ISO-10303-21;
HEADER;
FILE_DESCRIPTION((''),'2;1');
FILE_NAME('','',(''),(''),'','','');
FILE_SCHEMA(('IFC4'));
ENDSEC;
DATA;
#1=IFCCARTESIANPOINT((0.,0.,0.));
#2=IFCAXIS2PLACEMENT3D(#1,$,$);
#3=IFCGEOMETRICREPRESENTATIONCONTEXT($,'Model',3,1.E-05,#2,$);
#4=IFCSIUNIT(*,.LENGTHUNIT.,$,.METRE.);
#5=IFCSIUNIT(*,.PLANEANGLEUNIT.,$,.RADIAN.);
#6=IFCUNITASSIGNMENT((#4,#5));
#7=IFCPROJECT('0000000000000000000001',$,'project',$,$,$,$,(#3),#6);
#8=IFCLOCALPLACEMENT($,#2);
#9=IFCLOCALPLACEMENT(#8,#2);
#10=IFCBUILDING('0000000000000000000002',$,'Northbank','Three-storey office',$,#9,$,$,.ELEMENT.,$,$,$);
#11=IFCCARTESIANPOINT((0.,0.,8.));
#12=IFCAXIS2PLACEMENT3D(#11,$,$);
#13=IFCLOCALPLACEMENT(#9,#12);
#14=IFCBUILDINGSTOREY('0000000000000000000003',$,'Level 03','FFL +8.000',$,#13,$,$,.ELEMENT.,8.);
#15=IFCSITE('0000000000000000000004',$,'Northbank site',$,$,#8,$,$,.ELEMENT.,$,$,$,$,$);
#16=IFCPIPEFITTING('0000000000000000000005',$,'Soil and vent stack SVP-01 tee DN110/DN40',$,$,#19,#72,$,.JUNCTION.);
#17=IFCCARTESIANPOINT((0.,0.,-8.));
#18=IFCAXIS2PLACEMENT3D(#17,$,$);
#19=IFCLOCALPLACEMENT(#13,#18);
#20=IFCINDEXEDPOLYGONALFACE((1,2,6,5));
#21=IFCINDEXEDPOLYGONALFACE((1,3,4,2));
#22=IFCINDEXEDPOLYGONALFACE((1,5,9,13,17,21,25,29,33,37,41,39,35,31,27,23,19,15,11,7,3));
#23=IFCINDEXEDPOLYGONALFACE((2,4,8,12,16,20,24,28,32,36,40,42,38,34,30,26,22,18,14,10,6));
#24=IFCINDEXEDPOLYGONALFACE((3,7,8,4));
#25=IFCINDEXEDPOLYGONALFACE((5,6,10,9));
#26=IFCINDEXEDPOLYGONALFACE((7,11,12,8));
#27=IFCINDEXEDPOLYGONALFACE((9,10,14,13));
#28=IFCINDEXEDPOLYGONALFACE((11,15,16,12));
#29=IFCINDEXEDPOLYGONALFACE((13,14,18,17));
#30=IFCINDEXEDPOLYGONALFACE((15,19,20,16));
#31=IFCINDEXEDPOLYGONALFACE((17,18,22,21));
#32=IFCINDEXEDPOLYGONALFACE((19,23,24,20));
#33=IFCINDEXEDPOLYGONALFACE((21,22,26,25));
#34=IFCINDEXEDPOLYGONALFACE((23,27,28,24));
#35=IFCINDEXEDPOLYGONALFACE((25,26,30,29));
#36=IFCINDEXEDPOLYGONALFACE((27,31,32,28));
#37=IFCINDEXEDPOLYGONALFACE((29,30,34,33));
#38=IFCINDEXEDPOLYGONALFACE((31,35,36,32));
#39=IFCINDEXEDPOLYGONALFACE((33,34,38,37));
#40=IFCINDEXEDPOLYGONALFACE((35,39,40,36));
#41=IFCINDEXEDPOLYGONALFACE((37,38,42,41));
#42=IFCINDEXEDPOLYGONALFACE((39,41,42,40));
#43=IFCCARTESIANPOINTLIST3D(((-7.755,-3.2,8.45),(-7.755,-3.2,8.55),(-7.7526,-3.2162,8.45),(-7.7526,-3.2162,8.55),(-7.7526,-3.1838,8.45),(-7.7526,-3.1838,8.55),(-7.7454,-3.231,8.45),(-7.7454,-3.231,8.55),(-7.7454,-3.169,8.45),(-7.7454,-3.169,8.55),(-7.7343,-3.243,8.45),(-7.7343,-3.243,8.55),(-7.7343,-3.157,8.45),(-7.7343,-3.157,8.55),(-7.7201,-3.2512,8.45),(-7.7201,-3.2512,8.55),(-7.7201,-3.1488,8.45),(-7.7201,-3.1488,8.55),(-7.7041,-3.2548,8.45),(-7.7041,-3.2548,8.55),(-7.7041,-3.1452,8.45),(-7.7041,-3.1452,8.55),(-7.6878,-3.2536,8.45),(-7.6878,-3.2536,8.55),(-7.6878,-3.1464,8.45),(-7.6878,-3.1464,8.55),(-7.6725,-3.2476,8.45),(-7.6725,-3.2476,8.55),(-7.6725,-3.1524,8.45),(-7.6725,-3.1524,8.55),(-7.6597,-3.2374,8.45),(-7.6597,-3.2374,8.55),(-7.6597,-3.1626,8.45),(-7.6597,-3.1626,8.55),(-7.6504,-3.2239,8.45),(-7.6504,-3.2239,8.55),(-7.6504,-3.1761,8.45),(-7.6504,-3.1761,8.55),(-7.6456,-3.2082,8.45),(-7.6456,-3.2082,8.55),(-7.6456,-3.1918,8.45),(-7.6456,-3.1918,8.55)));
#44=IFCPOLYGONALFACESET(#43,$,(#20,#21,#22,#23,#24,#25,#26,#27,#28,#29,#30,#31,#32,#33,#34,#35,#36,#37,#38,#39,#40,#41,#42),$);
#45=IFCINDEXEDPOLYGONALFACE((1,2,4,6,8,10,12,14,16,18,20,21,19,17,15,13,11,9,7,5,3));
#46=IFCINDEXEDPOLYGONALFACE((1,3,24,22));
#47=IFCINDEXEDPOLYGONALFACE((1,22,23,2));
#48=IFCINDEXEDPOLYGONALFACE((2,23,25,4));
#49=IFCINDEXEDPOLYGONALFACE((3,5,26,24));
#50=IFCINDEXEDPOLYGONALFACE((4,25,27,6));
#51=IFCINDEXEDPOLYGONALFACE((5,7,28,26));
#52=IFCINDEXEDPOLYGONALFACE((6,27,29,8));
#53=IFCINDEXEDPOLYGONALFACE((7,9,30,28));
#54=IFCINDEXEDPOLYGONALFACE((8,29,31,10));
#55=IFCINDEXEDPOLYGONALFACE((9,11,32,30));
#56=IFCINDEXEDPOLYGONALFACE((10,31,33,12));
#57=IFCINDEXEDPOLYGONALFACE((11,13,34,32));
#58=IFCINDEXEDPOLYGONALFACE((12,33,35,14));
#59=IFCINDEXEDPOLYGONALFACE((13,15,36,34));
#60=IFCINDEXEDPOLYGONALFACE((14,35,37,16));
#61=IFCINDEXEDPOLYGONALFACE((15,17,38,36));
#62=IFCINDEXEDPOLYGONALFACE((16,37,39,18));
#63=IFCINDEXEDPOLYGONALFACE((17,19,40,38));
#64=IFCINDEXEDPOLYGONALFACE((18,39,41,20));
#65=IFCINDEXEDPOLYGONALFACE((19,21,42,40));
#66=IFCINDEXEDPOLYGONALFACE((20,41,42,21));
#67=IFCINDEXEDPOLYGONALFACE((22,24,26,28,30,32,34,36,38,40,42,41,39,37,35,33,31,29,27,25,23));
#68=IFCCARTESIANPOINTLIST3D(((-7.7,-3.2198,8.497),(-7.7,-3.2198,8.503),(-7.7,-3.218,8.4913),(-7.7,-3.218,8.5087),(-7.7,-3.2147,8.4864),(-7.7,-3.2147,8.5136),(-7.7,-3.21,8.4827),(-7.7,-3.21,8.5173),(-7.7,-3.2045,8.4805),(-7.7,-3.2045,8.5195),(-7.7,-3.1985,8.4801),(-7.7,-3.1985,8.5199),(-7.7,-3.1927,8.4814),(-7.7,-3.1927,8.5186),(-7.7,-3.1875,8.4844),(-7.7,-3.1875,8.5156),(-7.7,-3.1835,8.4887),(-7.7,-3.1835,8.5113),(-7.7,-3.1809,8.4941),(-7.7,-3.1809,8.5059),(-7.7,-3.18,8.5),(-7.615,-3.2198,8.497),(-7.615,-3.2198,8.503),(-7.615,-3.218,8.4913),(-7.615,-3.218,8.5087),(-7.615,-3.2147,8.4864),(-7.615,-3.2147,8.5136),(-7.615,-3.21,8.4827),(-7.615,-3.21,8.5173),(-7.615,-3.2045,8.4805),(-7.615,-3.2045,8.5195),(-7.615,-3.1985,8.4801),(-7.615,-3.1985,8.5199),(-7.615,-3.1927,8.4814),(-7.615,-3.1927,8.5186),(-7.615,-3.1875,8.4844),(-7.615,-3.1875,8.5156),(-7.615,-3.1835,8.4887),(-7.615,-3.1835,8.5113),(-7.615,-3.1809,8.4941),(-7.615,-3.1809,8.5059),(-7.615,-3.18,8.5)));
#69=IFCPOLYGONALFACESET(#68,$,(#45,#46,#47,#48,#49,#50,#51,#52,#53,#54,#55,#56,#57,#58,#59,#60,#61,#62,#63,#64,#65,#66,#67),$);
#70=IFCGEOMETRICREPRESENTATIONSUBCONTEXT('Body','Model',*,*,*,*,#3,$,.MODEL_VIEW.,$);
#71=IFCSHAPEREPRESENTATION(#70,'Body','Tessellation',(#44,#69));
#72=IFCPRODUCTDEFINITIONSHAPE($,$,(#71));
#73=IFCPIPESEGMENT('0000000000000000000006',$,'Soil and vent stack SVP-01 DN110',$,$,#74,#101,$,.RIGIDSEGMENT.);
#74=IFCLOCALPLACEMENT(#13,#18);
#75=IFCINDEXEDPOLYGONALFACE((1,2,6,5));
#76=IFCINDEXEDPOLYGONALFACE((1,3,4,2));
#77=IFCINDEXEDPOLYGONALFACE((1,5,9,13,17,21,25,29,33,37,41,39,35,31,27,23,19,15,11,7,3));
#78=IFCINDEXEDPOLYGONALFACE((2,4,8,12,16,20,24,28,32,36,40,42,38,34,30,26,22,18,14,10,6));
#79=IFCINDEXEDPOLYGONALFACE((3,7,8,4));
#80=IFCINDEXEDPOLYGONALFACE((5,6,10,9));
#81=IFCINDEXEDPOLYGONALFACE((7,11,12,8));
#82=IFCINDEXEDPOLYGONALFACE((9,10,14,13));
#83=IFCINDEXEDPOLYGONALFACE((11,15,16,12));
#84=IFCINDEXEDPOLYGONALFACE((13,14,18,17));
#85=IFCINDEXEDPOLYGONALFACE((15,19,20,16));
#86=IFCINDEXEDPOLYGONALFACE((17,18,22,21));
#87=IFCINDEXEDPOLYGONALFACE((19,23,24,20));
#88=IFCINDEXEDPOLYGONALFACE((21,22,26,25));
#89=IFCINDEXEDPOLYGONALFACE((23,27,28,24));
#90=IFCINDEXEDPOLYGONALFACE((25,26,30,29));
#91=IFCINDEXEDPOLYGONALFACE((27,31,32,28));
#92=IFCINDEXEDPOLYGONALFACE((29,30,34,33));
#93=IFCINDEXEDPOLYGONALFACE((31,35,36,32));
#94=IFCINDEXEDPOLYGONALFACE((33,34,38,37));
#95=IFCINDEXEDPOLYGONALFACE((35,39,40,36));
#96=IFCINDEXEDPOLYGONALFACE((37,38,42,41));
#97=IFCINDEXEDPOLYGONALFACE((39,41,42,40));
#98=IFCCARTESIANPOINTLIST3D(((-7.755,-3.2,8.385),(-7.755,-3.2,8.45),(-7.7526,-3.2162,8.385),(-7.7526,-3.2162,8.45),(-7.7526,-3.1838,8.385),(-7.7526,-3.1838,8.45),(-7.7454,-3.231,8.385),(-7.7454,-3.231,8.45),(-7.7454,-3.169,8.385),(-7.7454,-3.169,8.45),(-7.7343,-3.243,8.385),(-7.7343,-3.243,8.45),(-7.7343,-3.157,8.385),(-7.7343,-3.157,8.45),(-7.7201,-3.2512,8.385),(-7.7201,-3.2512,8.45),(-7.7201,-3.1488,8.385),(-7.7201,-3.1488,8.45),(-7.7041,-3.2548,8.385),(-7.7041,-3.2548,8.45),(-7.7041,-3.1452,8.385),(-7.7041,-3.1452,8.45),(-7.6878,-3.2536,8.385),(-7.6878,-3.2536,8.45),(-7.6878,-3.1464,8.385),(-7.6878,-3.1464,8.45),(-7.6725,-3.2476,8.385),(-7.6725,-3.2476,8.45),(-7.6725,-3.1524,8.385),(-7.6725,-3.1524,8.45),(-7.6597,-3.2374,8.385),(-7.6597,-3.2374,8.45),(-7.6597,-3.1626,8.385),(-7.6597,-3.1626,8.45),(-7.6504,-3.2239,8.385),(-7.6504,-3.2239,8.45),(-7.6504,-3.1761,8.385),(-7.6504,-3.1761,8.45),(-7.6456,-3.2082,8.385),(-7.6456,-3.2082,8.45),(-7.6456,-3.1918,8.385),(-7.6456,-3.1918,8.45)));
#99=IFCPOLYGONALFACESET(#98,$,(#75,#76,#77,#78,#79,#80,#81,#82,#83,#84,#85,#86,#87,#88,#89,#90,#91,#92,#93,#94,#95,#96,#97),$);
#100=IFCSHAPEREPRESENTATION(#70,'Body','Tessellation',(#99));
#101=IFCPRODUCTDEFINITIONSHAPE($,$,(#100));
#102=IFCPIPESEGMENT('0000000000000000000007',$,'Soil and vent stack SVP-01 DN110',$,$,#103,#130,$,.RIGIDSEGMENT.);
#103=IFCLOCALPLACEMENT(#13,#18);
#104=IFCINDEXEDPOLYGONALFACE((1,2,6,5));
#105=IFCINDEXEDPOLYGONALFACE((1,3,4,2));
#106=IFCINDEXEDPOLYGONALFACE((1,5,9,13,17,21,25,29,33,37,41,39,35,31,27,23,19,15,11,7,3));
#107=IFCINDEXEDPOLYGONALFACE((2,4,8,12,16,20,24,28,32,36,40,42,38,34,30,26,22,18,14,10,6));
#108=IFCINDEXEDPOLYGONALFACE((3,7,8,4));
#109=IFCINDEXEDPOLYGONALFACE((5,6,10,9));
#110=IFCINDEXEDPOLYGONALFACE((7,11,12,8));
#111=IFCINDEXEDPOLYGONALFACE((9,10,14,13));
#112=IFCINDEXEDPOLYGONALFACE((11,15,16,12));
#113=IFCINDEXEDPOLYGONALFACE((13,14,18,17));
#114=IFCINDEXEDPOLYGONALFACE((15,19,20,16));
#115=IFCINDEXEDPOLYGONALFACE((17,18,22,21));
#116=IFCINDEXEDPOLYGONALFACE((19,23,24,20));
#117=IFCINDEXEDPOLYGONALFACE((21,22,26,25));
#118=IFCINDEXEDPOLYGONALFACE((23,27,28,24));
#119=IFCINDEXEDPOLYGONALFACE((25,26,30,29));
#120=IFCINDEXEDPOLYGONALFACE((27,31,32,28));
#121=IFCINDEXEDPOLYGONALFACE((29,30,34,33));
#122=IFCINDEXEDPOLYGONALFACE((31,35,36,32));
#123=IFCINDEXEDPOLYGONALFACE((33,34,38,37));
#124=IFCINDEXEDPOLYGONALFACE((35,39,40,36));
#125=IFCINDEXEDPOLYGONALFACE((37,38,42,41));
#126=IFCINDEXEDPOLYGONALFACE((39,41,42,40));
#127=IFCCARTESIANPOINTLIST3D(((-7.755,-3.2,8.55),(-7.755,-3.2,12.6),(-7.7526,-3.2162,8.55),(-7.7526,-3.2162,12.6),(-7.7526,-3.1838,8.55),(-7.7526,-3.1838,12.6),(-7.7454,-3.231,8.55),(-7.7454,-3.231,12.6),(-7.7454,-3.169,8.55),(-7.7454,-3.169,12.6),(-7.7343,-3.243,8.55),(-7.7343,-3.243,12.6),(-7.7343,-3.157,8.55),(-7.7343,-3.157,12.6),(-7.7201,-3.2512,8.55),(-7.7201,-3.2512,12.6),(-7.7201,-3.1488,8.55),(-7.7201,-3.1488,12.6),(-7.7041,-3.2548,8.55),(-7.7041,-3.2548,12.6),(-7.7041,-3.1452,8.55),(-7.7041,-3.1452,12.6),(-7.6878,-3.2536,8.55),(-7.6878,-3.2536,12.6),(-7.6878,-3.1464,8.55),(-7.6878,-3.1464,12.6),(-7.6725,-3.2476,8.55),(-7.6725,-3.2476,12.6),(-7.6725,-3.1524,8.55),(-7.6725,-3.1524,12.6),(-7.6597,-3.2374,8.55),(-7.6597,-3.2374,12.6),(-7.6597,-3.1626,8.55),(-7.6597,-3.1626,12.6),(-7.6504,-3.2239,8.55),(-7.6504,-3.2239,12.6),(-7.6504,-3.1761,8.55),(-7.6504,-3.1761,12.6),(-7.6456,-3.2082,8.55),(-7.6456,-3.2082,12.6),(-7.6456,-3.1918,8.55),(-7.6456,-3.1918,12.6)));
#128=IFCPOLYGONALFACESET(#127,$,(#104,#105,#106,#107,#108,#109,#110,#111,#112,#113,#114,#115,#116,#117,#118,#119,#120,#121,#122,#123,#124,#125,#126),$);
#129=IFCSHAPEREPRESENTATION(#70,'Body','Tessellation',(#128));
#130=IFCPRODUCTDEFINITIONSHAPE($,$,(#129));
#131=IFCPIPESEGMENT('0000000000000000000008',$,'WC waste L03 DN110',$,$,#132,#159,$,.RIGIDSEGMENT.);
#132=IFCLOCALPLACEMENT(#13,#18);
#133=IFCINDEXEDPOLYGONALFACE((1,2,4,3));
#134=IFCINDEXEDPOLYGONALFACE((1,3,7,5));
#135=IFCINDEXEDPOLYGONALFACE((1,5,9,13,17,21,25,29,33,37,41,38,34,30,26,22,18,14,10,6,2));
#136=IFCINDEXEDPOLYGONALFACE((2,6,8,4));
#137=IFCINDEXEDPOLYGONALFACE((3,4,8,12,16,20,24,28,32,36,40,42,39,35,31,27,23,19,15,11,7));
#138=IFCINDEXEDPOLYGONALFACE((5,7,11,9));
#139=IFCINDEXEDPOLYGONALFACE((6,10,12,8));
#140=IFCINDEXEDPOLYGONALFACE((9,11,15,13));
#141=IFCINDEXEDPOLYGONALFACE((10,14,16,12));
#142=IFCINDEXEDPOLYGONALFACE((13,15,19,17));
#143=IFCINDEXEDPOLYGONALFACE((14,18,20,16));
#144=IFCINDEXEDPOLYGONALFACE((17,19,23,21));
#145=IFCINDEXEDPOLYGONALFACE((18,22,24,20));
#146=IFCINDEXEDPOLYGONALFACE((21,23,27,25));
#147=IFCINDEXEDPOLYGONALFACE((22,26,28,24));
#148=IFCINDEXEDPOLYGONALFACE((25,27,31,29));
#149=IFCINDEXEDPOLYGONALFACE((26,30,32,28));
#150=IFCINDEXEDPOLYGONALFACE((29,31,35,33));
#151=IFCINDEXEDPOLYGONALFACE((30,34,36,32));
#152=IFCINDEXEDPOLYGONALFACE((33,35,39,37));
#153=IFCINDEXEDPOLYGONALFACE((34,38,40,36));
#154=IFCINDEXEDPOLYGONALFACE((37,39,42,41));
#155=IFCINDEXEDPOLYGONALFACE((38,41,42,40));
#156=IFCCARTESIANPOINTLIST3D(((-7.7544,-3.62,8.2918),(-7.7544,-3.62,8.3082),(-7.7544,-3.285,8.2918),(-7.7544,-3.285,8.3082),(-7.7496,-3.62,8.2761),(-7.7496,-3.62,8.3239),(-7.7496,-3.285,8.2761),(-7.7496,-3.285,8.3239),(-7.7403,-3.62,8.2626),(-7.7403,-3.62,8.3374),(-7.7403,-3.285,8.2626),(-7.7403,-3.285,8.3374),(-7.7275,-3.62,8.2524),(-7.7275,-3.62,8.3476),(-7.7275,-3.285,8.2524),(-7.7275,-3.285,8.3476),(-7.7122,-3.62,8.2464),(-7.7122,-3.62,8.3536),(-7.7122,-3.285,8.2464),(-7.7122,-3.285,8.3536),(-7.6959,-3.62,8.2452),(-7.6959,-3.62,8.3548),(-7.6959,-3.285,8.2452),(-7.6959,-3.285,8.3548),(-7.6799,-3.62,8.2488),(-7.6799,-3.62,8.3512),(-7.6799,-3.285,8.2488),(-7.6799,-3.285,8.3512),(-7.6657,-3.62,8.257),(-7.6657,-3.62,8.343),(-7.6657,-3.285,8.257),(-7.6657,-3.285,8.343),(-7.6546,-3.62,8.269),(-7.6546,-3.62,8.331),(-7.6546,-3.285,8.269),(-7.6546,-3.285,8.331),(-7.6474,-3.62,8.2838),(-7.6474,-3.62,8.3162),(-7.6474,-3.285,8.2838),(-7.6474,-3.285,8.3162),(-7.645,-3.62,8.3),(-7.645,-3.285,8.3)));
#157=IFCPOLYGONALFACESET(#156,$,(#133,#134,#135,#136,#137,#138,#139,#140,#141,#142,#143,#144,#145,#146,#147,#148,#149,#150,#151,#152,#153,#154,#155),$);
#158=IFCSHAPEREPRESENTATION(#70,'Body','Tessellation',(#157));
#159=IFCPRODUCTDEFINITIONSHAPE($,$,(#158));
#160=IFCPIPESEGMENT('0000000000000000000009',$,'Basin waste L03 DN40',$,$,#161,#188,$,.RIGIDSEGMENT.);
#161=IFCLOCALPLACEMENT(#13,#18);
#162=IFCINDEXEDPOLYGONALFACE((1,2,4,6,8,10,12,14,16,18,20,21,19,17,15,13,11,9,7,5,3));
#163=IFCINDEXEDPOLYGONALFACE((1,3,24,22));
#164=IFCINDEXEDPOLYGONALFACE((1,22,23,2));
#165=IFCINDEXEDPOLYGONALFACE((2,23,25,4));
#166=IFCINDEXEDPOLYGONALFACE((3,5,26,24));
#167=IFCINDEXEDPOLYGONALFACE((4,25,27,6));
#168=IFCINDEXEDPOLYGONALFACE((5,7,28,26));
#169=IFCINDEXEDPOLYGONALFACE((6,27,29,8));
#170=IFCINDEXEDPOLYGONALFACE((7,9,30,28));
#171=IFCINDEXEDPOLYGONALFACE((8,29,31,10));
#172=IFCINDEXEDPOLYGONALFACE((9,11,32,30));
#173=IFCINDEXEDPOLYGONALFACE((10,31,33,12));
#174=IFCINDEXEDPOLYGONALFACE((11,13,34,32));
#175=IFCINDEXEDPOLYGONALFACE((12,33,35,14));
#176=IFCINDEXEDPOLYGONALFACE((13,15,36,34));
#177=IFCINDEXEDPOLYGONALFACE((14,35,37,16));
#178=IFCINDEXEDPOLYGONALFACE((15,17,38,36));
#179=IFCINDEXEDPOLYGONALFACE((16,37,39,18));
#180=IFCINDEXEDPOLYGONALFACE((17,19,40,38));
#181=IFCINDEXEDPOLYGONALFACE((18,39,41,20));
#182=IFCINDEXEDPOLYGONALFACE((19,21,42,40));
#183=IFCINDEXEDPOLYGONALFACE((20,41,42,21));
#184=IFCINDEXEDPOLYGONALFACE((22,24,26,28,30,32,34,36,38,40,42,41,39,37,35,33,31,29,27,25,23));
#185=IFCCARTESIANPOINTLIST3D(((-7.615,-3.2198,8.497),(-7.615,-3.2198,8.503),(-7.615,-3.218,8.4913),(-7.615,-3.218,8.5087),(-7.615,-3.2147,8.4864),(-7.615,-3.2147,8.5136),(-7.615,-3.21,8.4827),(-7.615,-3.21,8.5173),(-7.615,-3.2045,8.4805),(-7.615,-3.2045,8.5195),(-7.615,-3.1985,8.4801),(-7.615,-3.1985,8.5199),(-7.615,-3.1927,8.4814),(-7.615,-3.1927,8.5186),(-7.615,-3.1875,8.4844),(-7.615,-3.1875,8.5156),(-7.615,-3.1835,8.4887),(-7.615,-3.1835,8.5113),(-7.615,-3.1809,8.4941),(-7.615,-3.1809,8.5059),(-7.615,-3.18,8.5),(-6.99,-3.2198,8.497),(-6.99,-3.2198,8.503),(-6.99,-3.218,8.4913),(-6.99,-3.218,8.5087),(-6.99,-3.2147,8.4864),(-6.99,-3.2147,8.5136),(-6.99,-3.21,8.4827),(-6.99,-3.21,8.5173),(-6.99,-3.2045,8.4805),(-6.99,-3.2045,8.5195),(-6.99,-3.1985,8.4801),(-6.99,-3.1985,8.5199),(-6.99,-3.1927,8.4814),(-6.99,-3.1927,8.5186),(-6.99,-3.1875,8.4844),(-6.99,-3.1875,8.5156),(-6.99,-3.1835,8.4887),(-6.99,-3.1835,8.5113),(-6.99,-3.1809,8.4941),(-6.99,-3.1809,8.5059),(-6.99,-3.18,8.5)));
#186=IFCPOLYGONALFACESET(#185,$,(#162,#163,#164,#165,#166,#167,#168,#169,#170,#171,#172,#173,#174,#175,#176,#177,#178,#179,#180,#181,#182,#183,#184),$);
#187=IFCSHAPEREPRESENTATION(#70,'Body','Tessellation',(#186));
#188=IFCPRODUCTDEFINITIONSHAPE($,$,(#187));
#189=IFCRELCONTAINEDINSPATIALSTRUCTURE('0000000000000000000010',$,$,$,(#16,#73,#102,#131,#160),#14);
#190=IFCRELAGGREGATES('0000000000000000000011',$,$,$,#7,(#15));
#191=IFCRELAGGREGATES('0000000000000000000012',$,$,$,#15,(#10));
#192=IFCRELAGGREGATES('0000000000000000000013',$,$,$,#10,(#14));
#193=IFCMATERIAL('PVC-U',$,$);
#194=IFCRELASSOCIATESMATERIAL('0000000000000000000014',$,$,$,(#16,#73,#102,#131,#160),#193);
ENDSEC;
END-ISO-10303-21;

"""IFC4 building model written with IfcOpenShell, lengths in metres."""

from ifc_helpers import new_model, si_unit, frame, origin, place, context, subcontext, project, spatial, circle, extrude, material, element, save


model = new_model("IFC4")

# Units and contexts
model_context = context("Model", 3, precision=1e-05, world=origin())
body_context = subcontext(model_context, "Body", "Model", "MODEL_VIEW")
ifc_project = project(units=[si_unit("LENGTHUNIT", "METRE"), si_unit("PLANEANGLEUNIT", "RADIAN")], contexts=[model_context])

# Site, building, storey
site_placement = place(None, origin())
site = spatial("IfcSite", under=ifc_project, at=site_placement, Name="Northbank site", CompositionType="ELEMENT")
building_placement = place(site_placement, origin())
building = spatial("IfcBuilding", under=site, at=building_placement, Name="Northbank", Description="Three-storey office", CompositionType="ELEMENT")
storey_placement = place(building_placement, frame((0.0, 0.0, 8.0)))
storey = spatial("IfcBuildingStorey", under=building, at=storey_placement, Name="Level 03", Description="FFL +8.000", CompositionType="ELEMENT", Elevation=8.0)

# Pipe fitting
ifc_material_1 = material(Name="PVC-U")
pipe_fitting_1_placement = place(storey_placement, frame((0.0, 0.0, -8.0)))
element("IfcPipeFitting", 1, at=pipe_fitting_1_placement, inside=storey, material=ifc_material_1, Name="Soil and vent stack SVP-01 tee DN110/DN40", PredefinedType="JUNCTION", context=body_context, shape_type="SweptSolid", body=[
    extrude(circle(Radius=0.055), frame((-7.7, -3.2, 8.45), z_axis=(0.0, 0.0, 1.0), x_axis=(-1.0, 0.0, 0.0)), (0.0, 0.0, 1.0), 0.1),
    extrude(circle(Radius=0.02), frame((-7.7, -3.2, 8.5), z_axis=(1.0, 0.0, 0.0), x_axis=(0.0, 1.0, 0.0)), (0.0, 0.0, 1.0), 0.085),
])

# Pipe segments
pipe_segment_1_placement = place(storey_placement, frame((0.0, 0.0, -8.0)))
element("IfcPipeSegment", 2, at=pipe_segment_1_placement, inside=storey, material=ifc_material_1, Name="Soil and vent stack SVP-01 DN110", PredefinedType="RIGIDSEGMENT", context=body_context, shape_type="SweptSolid", body=[
    extrude(circle(Radius=0.055), frame((-7.7, -3.2, 8.385), z_axis=(0.0, 0.0, 1.0), x_axis=(-1.0, 0.0, 0.0)), (0.0, 0.0, 1.0), 0.065),
])
pipe_segment_2_placement = place(storey_placement, frame((0.0, 0.0, -8.0)))
element("IfcPipeSegment", 3, at=pipe_segment_2_placement, inside=storey, material=ifc_material_1, Name="Soil and vent stack SVP-01 DN110", PredefinedType="RIGIDSEGMENT", context=body_context, shape_type="SweptSolid", body=[
    extrude(circle(Radius=0.055), frame((-7.7, -3.2, 8.55), z_axis=(0.0, 0.0, 1.0), x_axis=(-1.0, 0.0, 0.0)), (0.0, 0.0, 1.0), 4.05),
])
pipe_segment_3_placement = place(storey_placement, frame((0.0, 0.0, -8.0)))
element("IfcPipeSegment", 4, at=pipe_segment_3_placement, inside=storey, material=ifc_material_1, Name="WC waste L03 DN110", PredefinedType="RIGIDSEGMENT", context=body_context, shape_type="SweptSolid", body=[
    extrude(circle(Radius=0.055), frame((-7.7, -3.285, 8.3), z_axis=(0.0, -1.0, 0.0), x_axis=(1.0, 0.0, 0.0)), (0.0, 0.0, 1.0), 0.335),
])
pipe_segment_4_placement = place(storey_placement, frame((0.0, 0.0, -8.0)))
element("IfcPipeSegment", 5, at=pipe_segment_4_placement, inside=storey, material=ifc_material_1, Name="Basin waste L03 DN40", PredefinedType="RIGIDSEGMENT", context=body_context, shape_type="SweptSolid", body=[
    extrude(circle(Radius=0.02), frame((-7.615, -3.2, 8.5), z_axis=(1.0, 0.0, 0.0), x_axis=(0.0, 1.0, 0.0)), (0.0, 0.0, 1.0), 0.625),
])

save(model, "model.ifc")
